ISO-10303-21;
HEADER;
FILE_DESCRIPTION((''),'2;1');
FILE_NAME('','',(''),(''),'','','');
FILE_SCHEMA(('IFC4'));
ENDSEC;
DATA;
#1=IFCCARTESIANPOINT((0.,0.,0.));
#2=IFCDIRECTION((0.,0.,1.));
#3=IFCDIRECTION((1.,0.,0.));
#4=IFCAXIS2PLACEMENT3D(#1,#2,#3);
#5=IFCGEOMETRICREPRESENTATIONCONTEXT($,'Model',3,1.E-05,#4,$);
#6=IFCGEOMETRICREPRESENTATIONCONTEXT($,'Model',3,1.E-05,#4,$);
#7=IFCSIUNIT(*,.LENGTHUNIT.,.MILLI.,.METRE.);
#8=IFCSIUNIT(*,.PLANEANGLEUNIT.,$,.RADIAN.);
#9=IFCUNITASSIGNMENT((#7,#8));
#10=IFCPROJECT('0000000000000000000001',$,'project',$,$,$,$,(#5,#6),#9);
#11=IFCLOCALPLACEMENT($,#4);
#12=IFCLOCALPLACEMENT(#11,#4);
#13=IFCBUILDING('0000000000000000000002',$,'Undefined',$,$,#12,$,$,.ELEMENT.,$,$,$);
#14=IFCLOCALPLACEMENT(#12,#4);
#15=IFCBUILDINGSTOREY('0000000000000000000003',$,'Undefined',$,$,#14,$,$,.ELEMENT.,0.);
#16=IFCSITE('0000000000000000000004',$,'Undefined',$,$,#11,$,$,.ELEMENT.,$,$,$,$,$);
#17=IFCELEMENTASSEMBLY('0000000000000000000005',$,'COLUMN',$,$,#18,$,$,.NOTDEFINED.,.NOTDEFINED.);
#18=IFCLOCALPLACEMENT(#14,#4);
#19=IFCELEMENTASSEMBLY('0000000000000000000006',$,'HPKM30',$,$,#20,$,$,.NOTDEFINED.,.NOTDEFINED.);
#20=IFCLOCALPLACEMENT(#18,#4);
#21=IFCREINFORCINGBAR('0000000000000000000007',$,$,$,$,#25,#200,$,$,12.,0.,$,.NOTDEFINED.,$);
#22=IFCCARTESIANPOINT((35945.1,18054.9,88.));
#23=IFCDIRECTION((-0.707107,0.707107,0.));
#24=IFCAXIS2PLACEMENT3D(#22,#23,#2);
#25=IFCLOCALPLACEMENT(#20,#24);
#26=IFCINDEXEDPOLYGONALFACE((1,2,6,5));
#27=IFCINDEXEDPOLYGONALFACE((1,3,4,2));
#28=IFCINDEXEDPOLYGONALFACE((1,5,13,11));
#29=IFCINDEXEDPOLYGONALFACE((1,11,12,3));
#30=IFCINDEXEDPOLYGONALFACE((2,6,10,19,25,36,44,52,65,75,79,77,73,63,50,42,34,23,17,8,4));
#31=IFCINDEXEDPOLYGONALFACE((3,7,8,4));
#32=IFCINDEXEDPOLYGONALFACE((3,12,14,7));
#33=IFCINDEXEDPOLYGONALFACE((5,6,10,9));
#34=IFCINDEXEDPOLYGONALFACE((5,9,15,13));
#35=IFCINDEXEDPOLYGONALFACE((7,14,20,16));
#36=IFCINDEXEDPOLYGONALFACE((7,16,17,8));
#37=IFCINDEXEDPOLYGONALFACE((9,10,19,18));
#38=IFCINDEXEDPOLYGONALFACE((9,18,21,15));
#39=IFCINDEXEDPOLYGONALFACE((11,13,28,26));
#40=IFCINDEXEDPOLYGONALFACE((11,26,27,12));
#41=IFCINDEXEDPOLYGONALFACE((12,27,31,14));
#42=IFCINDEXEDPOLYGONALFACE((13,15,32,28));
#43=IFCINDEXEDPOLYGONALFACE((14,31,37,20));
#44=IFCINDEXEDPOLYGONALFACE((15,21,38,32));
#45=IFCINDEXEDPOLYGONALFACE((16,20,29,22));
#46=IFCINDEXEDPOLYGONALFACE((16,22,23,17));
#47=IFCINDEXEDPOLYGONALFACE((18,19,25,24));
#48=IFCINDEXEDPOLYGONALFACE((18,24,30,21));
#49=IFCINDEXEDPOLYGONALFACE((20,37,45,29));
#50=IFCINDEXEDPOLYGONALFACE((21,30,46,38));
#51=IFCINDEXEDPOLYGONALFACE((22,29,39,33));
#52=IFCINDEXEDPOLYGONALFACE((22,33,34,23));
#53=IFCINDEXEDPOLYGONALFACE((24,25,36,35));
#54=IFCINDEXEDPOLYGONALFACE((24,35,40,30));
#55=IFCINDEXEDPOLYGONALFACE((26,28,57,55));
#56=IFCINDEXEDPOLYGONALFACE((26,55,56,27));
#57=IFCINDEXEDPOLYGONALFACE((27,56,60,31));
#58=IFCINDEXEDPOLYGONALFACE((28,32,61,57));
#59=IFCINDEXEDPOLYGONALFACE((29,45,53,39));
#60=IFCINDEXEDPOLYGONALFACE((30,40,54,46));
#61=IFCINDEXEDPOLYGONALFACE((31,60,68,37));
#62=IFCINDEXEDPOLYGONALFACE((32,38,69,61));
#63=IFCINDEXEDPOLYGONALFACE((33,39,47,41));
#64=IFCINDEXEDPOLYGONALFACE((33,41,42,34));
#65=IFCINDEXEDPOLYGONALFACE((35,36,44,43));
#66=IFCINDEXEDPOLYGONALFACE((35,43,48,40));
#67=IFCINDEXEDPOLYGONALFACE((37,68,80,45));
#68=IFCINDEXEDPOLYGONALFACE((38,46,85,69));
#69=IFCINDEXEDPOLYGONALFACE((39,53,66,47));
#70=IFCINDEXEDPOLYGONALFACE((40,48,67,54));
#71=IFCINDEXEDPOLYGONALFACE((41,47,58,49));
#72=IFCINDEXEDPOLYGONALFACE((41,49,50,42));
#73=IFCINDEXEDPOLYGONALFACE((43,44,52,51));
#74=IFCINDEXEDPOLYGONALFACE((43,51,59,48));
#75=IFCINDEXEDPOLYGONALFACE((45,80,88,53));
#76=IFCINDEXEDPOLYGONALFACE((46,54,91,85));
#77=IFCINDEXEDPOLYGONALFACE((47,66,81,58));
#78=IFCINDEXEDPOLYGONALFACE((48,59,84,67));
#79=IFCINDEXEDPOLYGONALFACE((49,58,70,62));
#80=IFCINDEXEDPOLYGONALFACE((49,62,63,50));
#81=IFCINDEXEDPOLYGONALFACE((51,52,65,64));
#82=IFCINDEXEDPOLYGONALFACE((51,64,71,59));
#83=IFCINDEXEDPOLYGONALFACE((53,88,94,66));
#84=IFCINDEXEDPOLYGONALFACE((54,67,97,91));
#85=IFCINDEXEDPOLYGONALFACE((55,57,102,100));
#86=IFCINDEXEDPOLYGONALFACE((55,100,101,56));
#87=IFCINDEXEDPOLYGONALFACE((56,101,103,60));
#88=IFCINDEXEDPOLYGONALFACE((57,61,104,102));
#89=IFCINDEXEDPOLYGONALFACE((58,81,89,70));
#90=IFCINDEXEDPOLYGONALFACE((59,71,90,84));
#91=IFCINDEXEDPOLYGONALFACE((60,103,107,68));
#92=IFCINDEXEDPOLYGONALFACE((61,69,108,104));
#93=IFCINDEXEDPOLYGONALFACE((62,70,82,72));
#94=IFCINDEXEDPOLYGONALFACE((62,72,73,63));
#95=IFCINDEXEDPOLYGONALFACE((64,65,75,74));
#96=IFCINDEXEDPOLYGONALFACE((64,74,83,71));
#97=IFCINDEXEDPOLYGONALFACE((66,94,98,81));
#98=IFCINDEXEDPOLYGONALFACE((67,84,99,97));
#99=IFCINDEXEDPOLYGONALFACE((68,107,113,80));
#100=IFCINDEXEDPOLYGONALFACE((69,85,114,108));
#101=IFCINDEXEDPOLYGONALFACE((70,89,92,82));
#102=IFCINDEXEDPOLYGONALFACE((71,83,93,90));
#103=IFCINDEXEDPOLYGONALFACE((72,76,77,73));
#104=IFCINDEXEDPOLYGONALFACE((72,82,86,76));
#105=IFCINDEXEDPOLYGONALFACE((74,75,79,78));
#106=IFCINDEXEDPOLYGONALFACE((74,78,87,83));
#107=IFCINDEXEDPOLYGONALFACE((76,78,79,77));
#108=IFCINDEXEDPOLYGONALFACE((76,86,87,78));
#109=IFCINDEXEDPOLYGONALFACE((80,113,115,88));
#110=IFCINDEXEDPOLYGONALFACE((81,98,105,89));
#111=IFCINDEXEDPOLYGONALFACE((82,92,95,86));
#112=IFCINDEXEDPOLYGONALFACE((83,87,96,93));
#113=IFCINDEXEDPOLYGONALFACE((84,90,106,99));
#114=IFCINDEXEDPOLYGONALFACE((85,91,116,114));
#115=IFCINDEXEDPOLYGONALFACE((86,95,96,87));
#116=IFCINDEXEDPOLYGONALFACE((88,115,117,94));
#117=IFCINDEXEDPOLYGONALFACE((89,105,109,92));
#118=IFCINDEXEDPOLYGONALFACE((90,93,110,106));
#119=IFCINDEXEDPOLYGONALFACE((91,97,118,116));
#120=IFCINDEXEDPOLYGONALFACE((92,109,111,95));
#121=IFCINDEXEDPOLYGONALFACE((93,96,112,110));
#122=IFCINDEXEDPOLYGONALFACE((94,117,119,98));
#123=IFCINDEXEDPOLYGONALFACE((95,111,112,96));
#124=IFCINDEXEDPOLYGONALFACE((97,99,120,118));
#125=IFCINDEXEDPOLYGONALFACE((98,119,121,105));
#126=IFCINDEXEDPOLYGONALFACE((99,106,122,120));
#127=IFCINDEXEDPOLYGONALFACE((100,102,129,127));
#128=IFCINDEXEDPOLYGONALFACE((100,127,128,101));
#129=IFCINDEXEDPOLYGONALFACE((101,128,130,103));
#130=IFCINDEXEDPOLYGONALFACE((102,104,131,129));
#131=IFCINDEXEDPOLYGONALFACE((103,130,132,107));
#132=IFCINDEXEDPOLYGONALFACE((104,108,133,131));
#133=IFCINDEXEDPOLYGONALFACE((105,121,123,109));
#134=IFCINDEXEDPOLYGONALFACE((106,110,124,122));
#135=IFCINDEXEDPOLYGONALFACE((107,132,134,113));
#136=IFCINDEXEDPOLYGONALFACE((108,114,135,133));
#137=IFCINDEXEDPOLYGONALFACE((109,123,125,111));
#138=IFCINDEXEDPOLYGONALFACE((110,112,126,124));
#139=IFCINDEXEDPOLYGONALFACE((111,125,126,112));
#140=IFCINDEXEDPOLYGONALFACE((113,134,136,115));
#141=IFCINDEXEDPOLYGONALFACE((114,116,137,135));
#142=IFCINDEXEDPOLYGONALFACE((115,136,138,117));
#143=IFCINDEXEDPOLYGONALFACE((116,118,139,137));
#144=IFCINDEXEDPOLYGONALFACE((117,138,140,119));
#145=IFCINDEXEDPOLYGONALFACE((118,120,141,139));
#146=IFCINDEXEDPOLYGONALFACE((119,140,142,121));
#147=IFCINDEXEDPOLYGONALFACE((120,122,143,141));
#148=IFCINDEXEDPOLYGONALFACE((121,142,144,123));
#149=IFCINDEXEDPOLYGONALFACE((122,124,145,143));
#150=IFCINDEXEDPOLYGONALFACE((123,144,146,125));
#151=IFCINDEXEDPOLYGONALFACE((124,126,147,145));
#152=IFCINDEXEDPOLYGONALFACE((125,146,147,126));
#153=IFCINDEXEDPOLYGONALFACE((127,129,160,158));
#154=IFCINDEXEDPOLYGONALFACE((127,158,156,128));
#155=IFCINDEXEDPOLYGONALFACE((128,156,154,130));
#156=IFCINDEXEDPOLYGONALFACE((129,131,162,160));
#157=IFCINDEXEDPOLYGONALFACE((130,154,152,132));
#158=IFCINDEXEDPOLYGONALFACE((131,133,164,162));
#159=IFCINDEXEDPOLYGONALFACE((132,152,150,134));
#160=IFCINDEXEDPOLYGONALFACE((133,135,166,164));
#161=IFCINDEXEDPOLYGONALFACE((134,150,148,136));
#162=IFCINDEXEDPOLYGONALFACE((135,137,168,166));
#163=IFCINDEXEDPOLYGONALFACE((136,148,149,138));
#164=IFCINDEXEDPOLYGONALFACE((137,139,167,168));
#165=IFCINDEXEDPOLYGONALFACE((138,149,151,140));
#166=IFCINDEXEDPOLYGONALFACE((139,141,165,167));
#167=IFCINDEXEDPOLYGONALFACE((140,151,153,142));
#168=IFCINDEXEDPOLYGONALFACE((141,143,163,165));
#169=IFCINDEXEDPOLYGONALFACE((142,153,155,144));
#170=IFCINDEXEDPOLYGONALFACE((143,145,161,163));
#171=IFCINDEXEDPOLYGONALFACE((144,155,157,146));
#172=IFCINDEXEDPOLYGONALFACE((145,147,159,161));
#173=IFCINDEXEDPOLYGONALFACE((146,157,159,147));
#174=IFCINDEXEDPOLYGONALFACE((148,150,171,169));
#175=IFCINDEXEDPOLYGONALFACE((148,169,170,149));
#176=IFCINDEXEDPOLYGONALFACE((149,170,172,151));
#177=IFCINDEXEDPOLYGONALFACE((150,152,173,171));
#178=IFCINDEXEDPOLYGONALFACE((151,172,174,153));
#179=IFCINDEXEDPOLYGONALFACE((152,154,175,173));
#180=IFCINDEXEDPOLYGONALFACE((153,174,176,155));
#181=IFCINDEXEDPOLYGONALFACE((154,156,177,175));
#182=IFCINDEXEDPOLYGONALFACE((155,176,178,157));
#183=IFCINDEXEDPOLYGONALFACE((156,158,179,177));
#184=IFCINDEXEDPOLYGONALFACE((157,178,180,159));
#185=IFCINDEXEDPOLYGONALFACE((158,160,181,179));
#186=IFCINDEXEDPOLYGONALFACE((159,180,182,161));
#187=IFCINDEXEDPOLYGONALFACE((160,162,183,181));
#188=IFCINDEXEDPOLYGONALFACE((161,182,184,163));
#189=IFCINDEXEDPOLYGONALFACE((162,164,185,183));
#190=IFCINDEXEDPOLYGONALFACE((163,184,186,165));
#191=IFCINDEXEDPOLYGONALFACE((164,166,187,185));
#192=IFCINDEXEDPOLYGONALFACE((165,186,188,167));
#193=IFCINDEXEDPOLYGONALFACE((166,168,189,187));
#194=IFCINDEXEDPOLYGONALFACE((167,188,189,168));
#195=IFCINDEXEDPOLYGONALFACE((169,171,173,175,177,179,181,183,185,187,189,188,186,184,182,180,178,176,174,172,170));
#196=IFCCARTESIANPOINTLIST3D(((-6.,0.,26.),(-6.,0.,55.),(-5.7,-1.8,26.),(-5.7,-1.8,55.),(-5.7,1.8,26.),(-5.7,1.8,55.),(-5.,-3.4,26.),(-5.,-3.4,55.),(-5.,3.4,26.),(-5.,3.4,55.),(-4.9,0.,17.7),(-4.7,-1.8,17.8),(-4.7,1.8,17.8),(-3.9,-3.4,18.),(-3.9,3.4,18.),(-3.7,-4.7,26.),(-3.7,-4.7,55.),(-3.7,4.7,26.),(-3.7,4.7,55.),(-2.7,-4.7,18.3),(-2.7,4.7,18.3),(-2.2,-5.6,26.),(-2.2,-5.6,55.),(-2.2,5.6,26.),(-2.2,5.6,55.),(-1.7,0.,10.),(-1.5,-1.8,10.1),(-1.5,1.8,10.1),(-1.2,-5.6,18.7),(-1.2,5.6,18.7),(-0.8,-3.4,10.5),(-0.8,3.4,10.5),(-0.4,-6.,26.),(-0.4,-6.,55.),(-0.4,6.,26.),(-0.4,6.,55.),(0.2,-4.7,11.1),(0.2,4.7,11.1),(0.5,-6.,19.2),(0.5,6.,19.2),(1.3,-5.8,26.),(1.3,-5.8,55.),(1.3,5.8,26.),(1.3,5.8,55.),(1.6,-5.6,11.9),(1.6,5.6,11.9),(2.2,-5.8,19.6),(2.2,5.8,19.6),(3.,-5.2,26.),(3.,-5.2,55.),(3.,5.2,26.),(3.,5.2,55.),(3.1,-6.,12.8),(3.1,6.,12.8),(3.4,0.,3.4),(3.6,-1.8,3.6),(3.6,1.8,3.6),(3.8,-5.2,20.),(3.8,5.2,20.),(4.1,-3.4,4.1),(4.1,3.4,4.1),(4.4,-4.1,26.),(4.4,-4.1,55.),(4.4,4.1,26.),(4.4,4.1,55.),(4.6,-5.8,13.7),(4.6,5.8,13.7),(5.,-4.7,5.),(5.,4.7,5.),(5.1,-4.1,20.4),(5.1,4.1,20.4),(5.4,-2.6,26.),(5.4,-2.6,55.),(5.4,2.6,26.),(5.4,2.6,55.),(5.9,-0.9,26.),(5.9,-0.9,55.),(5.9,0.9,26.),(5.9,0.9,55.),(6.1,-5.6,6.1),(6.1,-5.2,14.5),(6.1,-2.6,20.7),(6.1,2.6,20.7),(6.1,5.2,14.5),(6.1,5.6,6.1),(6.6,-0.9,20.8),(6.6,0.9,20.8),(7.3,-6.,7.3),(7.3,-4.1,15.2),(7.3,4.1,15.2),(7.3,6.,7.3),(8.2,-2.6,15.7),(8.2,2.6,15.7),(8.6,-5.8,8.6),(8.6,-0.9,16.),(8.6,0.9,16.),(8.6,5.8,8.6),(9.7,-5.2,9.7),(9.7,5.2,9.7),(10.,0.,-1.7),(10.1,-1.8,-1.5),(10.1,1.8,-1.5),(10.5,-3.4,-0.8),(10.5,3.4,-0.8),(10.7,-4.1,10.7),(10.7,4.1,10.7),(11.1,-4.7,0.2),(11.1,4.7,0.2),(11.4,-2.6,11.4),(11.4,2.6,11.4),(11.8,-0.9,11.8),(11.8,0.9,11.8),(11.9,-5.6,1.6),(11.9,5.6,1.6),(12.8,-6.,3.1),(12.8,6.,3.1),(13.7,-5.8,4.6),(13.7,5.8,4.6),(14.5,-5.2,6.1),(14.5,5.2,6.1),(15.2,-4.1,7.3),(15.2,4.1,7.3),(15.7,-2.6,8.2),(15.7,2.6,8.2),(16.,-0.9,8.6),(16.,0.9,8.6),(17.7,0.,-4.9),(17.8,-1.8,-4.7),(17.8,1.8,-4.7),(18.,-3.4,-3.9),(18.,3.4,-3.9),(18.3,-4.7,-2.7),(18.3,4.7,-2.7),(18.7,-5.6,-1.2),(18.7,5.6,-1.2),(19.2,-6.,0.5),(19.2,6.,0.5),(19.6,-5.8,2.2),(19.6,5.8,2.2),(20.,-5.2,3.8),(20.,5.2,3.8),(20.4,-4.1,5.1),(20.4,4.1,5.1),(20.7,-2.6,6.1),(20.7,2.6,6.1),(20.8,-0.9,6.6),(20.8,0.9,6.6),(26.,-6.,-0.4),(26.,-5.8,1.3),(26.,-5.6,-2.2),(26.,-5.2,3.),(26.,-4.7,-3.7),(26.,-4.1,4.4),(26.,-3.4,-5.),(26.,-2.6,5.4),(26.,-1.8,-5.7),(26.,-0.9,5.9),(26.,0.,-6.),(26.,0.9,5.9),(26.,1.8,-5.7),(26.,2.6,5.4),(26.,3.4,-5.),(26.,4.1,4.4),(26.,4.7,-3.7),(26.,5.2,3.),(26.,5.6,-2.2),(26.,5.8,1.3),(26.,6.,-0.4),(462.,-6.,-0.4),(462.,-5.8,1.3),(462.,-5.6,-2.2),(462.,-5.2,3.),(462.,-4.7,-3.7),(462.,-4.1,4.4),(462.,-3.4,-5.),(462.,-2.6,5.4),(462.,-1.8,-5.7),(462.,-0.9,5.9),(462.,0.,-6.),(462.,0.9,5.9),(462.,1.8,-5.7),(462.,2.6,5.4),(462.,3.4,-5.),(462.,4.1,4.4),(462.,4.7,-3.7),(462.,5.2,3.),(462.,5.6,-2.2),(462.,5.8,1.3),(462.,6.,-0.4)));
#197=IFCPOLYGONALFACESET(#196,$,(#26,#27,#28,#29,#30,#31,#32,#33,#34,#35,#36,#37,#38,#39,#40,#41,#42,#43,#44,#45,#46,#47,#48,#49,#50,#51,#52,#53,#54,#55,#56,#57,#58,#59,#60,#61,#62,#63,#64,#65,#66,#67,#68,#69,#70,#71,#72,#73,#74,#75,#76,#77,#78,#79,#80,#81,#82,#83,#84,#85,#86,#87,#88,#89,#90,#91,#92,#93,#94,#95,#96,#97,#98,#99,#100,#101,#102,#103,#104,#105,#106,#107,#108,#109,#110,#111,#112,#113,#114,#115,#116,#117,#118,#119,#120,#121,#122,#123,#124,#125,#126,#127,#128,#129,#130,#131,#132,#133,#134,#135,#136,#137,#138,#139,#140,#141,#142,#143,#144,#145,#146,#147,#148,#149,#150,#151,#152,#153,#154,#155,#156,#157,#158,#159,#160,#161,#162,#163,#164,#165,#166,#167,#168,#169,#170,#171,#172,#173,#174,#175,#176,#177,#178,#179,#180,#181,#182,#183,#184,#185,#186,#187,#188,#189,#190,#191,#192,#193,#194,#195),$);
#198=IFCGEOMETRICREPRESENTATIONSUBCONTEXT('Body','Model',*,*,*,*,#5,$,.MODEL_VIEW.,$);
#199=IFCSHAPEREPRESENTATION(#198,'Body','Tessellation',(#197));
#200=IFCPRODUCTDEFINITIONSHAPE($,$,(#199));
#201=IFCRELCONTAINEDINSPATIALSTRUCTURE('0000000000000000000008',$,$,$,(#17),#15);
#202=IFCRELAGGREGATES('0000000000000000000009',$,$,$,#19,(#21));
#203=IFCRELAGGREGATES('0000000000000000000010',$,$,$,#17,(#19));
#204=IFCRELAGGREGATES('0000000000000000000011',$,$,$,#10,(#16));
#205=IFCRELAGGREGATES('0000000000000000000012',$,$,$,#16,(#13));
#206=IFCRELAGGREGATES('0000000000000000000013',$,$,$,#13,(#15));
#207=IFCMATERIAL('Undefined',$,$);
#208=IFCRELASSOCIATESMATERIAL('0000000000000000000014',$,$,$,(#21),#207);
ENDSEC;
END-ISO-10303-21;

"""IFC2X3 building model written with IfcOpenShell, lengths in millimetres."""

from ifc_helpers import new_model, entity, si_unit, frame, origin_with_axes, place, context, subcontext, project, spatial, source, transform, mapped, material, element, aggregate, save


model = new_model("IFC2X3")

# Units and contexts
model_context_1 = context("Model", 3, precision=1e-05, world=origin_with_axes())
model_context_2 = context("Model", 3, precision=1e-05, world=origin_with_axes())
body_context = subcontext(model_context_1, "Body", "Model", "MODEL_VIEW")
ifc_project = project(units=[si_unit("LENGTHUNIT", "METRE", prefix="MILLI"), si_unit("PLANEANGLEUNIT", "RADIAN")], contexts=[model_context_1, model_context_2])

# Site, building, storey
site_placement = place(None, origin_with_axes())
site = spatial("IfcSite", under=ifc_project, at=site_placement, Name="Undefined", CompositionType="ELEMENT")
building_placement = place(site_placement, origin_with_axes())
building = spatial("IfcBuilding", under=site, at=building_placement, Name="Undefined", CompositionType="ELEMENT")
storey_placement = place(building_placement, origin_with_axes())
storey = spatial("IfcBuildingStorey", under=building, at=storey_placement, Name="Undefined", CompositionType="ELEMENT", Elevation=0.0)

# Element assembly
assembly_1_placement = place(storey_placement, origin_with_axes())
assembly_1 = element("IfcElementAssembly", 1, at=assembly_1_placement, inside=storey, Name="COLUMN", AssemblyPlace="NOTDEFINED", PredefinedType="NOTDEFINED")

# Element assembly
assembly_2_placement = place(assembly_1_placement, origin_with_axes())
assembly_2 = element("IfcElementAssembly", 2, at=assembly_2_placement, Name="HPKM30", AssemblyPlace="NOTDEFINED", PredefinedType="NOTDEFINED")

# Shared definitions
ifc_material_1 = material(Name="Undefined")

# Reinforcing bar
shared_shape_1 = source(origin_with_axes(), body_context, "Body", "AdvancedSweptSolid", [
    entity("IfcSweptDiskSolid", entity("IfcCompositeCurve", [entity("IfcCompositeCurveSegment", "CONTINUOUS", True, entity("IfcTrimmedCurve", entity("IfcLine", entity("IfcCartesianPoint", [0.0, 0.0, 0.0]), entity("IfcVector", entity("IfcDirection", [0.0, 0.0, -1.0]), 1.0)), [entity("IfcParameterValue", 0.0)], [entity("IfcParameterValue", 29.0)], True, "PARAMETER")), entity("IfcCompositeCurveSegment", "CONTINUOUS", True, entity("IfcTrimmedCurve", entity("IfcCircle", entity("IfcAxis2Placement3D", entity("IfcCartesianPoint", [26.0, 0.0, -29.0]), entity("IfcDirection", [0.0, -1.0, 0.0]), entity("IfcDirection", [-1.0, 0.0, 0.0])), 26.0), [entity("IfcParameterValue", 0.0)], [entity("IfcParameterValue", 1.570796)], True, "PARAMETER")), entity("IfcCompositeCurveSegment", "DISCONTINUOUS", True, entity("IfcTrimmedCurve", entity("IfcLine", entity("IfcCartesianPoint", [26.0, 0.0, -55.0]), entity("IfcVector", entity("IfcDirection", [1.0, 0.0, 0.0]), 1.0)), [entity("IfcParameterValue", 0.0)], [entity("IfcParameterValue", 436.0)], True, "PARAMETER"))], False), 6.0, None, 0.0, 466.6),
])
reinforcing_bar_1_placement = place(assembly_2_placement, frame((35945.1, 18054.9, 88.0), z_axis=(-0.707107, 0.707107, 0.0), x_axis=(0.0, 0.0, 1.0)))
reinforcing_bar_1 = element("IfcReinforcingBar", 3, at=reinforcing_bar_1_placement, material=ifc_material_1, BarRole="NOTDEFINED", CrossSectionArea=0.0, NominalDiameter=12.0, context=body_context, shape_type="MappedRepresentation", body=[
    mapped(shared_shape_1, transform((0.0, 0.0, 55.0))),
])
aggregate(assembly_2, [reinforcing_bar_1])
aggregate(assembly_1, [assembly_2])

save(model, "model.ifc")
